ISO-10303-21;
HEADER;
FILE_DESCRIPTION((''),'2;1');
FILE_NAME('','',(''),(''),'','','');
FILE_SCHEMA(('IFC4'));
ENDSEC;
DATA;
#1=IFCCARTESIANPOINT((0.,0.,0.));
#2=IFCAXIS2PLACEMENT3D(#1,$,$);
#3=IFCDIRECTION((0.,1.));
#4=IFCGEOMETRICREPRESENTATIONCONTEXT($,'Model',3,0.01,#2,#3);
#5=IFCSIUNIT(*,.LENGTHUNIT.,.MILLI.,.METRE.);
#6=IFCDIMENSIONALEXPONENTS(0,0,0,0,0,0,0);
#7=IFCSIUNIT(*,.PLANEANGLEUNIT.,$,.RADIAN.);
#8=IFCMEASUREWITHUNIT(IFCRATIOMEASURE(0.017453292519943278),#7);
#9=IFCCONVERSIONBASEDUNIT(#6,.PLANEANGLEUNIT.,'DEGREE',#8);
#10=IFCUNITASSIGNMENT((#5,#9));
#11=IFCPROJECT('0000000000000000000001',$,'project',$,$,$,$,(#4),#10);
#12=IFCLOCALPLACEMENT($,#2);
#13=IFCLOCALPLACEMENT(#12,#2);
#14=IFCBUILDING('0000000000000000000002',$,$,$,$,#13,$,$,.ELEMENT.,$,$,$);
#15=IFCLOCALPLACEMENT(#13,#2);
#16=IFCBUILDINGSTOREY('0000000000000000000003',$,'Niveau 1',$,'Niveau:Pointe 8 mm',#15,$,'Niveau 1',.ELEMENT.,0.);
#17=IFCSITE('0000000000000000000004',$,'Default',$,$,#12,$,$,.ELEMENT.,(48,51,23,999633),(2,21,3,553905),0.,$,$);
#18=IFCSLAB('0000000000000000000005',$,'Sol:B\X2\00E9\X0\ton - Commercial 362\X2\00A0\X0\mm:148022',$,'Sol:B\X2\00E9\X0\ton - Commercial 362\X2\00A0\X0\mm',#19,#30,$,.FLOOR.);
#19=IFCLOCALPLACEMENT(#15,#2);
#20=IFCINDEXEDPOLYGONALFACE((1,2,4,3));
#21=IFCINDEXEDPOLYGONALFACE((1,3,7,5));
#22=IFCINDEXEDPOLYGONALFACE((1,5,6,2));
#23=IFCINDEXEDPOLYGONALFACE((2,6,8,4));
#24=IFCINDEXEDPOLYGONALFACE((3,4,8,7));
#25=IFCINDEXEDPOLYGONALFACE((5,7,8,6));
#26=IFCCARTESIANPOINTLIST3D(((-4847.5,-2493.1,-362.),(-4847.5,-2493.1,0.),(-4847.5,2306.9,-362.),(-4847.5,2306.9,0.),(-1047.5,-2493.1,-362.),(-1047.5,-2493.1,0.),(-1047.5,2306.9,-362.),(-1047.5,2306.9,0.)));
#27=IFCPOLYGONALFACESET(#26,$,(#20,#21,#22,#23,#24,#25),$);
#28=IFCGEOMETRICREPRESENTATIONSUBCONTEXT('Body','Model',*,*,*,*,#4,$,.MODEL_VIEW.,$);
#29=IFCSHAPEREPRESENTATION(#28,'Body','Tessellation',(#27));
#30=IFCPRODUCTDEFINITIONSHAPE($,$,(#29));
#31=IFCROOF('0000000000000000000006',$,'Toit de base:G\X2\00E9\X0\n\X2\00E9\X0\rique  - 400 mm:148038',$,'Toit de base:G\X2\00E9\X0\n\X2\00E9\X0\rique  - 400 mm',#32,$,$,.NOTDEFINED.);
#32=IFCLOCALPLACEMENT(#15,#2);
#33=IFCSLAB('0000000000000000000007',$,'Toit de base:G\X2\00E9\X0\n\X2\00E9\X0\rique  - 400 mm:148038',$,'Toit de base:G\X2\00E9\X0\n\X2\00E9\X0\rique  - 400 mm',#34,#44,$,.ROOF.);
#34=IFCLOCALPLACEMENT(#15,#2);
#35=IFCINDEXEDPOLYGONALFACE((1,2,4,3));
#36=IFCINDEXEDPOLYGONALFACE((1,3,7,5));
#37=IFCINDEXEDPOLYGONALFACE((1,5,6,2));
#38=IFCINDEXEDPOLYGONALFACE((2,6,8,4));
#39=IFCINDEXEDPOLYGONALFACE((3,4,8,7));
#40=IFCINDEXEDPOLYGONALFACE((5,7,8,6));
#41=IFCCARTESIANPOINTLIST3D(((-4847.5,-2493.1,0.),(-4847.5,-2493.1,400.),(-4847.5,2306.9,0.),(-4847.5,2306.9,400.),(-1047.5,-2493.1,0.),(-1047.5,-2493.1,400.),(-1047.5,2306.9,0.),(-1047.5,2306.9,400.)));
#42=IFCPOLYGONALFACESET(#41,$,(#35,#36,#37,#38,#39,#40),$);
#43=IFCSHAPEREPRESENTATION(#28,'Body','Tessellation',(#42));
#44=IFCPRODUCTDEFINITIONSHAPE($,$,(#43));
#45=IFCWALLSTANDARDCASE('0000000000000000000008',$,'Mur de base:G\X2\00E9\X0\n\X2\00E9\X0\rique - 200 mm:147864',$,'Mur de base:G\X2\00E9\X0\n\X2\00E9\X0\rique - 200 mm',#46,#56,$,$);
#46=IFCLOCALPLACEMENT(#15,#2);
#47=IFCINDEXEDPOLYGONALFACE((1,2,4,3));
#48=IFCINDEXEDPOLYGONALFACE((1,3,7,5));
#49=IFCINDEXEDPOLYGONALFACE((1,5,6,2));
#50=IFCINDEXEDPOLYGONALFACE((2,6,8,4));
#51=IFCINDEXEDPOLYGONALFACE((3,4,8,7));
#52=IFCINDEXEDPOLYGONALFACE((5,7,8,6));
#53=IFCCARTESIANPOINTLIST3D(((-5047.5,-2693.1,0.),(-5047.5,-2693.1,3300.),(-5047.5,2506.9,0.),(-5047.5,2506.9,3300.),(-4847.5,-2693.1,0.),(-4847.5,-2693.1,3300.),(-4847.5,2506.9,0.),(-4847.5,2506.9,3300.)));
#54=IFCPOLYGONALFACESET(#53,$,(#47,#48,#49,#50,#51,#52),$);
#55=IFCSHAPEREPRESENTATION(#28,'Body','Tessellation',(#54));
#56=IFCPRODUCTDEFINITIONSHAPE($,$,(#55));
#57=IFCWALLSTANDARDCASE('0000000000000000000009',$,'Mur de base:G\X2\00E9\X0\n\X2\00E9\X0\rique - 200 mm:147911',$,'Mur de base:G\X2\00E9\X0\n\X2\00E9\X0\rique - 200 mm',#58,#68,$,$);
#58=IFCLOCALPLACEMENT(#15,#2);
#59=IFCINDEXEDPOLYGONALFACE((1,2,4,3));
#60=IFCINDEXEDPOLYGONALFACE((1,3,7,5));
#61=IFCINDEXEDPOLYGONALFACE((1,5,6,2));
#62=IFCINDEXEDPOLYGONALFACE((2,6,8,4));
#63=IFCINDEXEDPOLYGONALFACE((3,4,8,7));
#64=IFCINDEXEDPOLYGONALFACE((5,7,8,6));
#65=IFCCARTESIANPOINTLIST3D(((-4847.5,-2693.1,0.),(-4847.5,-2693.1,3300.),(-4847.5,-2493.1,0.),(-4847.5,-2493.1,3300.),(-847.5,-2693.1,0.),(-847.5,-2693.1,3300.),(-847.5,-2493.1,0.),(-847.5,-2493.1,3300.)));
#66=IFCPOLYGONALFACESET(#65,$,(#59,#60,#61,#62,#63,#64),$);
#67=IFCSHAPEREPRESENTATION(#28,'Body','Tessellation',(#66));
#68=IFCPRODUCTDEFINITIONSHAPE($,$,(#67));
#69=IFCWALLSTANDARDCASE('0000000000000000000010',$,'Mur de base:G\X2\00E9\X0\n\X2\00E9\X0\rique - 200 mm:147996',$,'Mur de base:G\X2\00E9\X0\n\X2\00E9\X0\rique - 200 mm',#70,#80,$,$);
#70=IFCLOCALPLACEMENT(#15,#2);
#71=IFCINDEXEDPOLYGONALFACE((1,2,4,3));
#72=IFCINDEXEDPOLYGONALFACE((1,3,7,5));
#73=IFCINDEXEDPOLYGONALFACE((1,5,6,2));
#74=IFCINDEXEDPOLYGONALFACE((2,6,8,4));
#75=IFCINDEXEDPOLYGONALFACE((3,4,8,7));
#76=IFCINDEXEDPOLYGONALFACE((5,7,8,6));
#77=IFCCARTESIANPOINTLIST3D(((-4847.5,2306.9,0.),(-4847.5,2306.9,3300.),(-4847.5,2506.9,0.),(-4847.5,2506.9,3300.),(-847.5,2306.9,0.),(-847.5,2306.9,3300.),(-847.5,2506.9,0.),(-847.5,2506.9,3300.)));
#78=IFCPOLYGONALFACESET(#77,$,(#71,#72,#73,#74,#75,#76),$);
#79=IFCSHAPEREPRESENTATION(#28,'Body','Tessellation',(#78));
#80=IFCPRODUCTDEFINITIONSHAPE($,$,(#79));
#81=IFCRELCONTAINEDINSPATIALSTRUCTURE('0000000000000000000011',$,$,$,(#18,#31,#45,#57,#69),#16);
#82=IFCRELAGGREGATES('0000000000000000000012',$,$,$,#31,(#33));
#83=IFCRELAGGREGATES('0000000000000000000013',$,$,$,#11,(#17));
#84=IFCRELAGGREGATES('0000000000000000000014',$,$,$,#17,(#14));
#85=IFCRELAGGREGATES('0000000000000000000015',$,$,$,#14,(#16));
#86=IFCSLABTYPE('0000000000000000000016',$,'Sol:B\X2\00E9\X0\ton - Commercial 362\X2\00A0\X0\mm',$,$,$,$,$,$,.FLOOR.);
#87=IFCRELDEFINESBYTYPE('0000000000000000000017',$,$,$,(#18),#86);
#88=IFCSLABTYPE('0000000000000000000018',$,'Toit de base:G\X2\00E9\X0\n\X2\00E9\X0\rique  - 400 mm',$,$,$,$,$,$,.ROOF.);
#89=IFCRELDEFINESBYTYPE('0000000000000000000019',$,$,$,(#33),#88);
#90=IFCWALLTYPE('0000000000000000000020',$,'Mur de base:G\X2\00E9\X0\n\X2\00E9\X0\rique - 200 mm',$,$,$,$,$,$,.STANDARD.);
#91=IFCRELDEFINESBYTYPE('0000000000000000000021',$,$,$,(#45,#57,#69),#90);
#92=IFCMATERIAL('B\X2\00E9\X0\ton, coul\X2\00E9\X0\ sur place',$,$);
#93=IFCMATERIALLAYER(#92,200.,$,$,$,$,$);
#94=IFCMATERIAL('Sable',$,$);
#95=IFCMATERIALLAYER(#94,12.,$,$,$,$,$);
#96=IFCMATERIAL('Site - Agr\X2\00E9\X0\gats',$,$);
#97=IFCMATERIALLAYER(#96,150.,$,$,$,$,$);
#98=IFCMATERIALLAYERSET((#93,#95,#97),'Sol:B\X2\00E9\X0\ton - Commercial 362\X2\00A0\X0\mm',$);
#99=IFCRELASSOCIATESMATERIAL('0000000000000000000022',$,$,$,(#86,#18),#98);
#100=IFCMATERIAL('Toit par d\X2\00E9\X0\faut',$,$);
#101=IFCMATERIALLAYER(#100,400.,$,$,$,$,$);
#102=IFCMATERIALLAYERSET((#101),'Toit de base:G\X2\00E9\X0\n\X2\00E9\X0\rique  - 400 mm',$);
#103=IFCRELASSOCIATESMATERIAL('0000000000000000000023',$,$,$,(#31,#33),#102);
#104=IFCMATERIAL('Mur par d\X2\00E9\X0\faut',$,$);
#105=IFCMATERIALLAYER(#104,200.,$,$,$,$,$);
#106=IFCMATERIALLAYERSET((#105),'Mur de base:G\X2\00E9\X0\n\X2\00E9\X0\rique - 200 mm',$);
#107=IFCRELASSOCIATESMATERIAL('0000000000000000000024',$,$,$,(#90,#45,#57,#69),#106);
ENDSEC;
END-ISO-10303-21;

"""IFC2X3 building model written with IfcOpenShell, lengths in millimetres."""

from ifc_helpers import new_model, entity, si_unit, converted_unit, direction, frame, frame_2d, origin, place, context, subcontext, project, spatial, rectangle, extrude, material, layer, layer_set, layer_usage, type_object, element, aggregate, save


model = new_model("IFC2X3")

# Units and contexts
model_context = context("Model", 3, precision=0.01, world=origin(), true_north=direction((0.0, 1.0)))
body_context = subcontext(model_context, "Body", "Model", "MODEL_VIEW")
ifc_project = project(units=[si_unit("LENGTHUNIT", "METRE", prefix="MILLI"), converted_unit("PLANEANGLEUNIT", "DEGREE", entity("IfcRatioMeasure", 0.017453292519943278), si_unit("PLANEANGLEUNIT", "RADIAN"), dimensions=[0, 0, 0, 0, 0, 0, 0])], contexts=[model_context])

# Site, building, storey
site_placement = place(None, origin())
site = spatial("IfcSite", under=ifc_project, at=site_placement, Name="Default", CompositionType="ELEMENT", RefLatitude=(48, 51, 23, 999633), RefLongitude=(2, 21, 3, 553905), RefElevation=0.0)
building_placement = place(site_placement, origin())
building = spatial("IfcBuilding", under=site, at=building_placement, CompositionType="ELEMENT")
storey_placement = place(building_placement, origin())
storey = spatial("IfcBuildingStorey", under=building, at=storey_placement, Name="Niveau 1", ObjectType="Niveau:Pointe 8 mm", LongName="Niveau 1", CompositionType="ELEMENT", Elevation=0.0)

# Slab
ifc_material_1 = material(Name="Béton, coulé sur place")
ifc_layer_1 = layer(ifc_material_1, 200.0)
ifc_material_2 = material(Name="Sable")
ifc_layer_2 = layer(ifc_material_2, 12.0)
ifc_material_3 = material(Name="Site - Agrégats")
ifc_layer_3 = layer(ifc_material_3, 150.0)
ifc_layer_set_1 = layer_set([ifc_layer_1, ifc_layer_2, ifc_layer_3], Name="Sol:Béton - Commercial 362 mm")
ifc_layer_usage_1 = layer_usage(ifc_layer_set_1, "AXIS3", "POSITIVE", 0.0)
slab_type_1 = type_object("IfcSlabType", Name="Sol:Béton - Commercial 362 mm", PredefinedType="FLOOR", material=ifc_layer_set_1)
slab_1_placement = place(storey_placement, origin())
element("IfcSlab", 1, at=slab_1_placement, inside=storey, type_object=slab_type_1, material=ifc_layer_usage_1, Name="Sol:Béton - Commercial 362 mm:148022", ObjectType="Sol:Béton - Commercial 362 mm", PredefinedType="FLOOR", context=body_context, shape_type="SweptSolid", body=[
    extrude(rectangle(XDim=4800.0, YDim=3800.0, at=frame_2d((0.0, 0.0), x_axis=(1.0, 0.0))), frame((-2947.5, -93.1, 0.0), z_axis=(0.0, 0.0, -1.0), x_axis=(0.0, 1.0, 0.0)), (0.0, 0.0, 1.0), 362.0),
])

# Roof, slab
ifc_material_4 = material(Name="Toit par défaut")
ifc_layer_4 = layer(ifc_material_4, 400.0)
ifc_layer_set_2 = layer_set([ifc_layer_4], Name="Toit de base:Générique  - 400 mm")
roof_placement = place(storey_placement, frame((-4847.5, -2493.1, 0.0)))
roof = element("IfcRoof", 2, at=roof_placement, inside=storey, material=ifc_layer_set_2, Name="Toit de base:Générique  - 400 mm:148038", ObjectType="Toit de base:Générique  - 400 mm", ShapeType="NOTDEFINED")
slab_type_2 = type_object("IfcSlabType", Name="Toit de base:Générique  - 400 mm", PredefinedType="ROOF")
slab_2_placement = place(roof_placement, origin())
slab_2 = element("IfcSlab", 3, at=slab_2_placement, type_object=slab_type_2, material=ifc_layer_set_2, Name="Toit de base:Générique  - 400 mm:148038", ObjectType="Toit de base:Générique  - 400 mm", PredefinedType="ROOF", context=body_context, shape_type="SweptSolid", body=[
    extrude(rectangle(XDim=3800.0, YDim=4800.0, at=frame_2d((0.0, 0.0), x_axis=(1.0, 0.0))), frame((1900.0, 2400.0, 0.0)), (0.0, 0.0, 1.0), 400.0),
])
aggregate(roof, [slab_2])

# Walls
ifc_material_5 = material(Name="Mur par défaut")
ifc_layer_5 = layer(ifc_material_5, 200.0)
ifc_layer_set_3 = layer_set([ifc_layer_5], Name="Mur de base:Générique - 200 mm")
ifc_layer_usage_2 = layer_usage(ifc_layer_set_3, "AXIS2", "NEGATIVE", 100.0)
wall_type = type_object("IfcWallType", Name="Mur de base:Générique - 200 mm", PredefinedType="STANDARD", material=ifc_layer_set_3)
wall_1_placement = place(storey_placement, frame((-4947.5, 2506.9, 0.0), z_axis=(0.0, 0.0, 1.0), x_axis=(0.0, -1.0, 0.0)))
element("IfcWallStandardCase", 4, at=wall_1_placement, inside=storey, type_object=wall_type, material=ifc_layer_usage_2, Name="Mur de base:Générique - 200 mm:147864", ObjectType="Mur de base:Générique - 200 mm", context=body_context, shape_type="SweptSolid", body=[
    extrude(rectangle(XDim=5200.0, YDim=200.0, at=frame_2d((2600.0, 0.0), x_axis=(-1.0, 0.0))), origin(), (0.0, 0.0, 1.0), 3300.0),
])
ifc_layer_usage_3 = layer_usage(ifc_layer_set_3, "AXIS2", "NEGATIVE", 100.0)
wall_2_placement = place(storey_placement, frame((-4847.5, -2593.1, 0.0)))
element("IfcWallStandardCase", 5, at=wall_2_placement, inside=storey, type_object=wall_type, material=ifc_layer_usage_3, Name="Mur de base:Générique - 200 mm:147911", ObjectType="Mur de base:Générique - 200 mm", context=body_context, shape_type="SweptSolid", body=[
    extrude(rectangle(XDim=4000.0, YDim=200.0, at=frame_2d((2000.0, 0.0), x_axis=(-1.0, 0.0))), origin(), (0.0, 0.0, 1.0), 3300.0),
])
ifc_layer_usage_4 = layer_usage(ifc_layer_set_3, "AXIS2", "NEGATIVE", 100.0)
wall_3_placement = place(storey_placement, frame((-847.5, 2406.9, 0.0), z_axis=(0.0, 0.0, 1.0), x_axis=(-1.0, 0.0, 0.0)))
element("IfcWallStandardCase", 6, at=wall_3_placement, inside=storey, type_object=wall_type, material=ifc_layer_usage_4, Name="Mur de base:Générique - 200 mm:147996", ObjectType="Mur de base:Générique - 200 mm", context=body_context, shape_type="SweptSolid", body=[
    extrude(rectangle(XDim=4000.0, YDim=200.0, at=frame_2d((2000.0, 0.0), x_axis=(-1.0, 0.0))), origin(), (0.0, 0.0, 1.0), 3300.0),
])

save(model, "model.ifc")
